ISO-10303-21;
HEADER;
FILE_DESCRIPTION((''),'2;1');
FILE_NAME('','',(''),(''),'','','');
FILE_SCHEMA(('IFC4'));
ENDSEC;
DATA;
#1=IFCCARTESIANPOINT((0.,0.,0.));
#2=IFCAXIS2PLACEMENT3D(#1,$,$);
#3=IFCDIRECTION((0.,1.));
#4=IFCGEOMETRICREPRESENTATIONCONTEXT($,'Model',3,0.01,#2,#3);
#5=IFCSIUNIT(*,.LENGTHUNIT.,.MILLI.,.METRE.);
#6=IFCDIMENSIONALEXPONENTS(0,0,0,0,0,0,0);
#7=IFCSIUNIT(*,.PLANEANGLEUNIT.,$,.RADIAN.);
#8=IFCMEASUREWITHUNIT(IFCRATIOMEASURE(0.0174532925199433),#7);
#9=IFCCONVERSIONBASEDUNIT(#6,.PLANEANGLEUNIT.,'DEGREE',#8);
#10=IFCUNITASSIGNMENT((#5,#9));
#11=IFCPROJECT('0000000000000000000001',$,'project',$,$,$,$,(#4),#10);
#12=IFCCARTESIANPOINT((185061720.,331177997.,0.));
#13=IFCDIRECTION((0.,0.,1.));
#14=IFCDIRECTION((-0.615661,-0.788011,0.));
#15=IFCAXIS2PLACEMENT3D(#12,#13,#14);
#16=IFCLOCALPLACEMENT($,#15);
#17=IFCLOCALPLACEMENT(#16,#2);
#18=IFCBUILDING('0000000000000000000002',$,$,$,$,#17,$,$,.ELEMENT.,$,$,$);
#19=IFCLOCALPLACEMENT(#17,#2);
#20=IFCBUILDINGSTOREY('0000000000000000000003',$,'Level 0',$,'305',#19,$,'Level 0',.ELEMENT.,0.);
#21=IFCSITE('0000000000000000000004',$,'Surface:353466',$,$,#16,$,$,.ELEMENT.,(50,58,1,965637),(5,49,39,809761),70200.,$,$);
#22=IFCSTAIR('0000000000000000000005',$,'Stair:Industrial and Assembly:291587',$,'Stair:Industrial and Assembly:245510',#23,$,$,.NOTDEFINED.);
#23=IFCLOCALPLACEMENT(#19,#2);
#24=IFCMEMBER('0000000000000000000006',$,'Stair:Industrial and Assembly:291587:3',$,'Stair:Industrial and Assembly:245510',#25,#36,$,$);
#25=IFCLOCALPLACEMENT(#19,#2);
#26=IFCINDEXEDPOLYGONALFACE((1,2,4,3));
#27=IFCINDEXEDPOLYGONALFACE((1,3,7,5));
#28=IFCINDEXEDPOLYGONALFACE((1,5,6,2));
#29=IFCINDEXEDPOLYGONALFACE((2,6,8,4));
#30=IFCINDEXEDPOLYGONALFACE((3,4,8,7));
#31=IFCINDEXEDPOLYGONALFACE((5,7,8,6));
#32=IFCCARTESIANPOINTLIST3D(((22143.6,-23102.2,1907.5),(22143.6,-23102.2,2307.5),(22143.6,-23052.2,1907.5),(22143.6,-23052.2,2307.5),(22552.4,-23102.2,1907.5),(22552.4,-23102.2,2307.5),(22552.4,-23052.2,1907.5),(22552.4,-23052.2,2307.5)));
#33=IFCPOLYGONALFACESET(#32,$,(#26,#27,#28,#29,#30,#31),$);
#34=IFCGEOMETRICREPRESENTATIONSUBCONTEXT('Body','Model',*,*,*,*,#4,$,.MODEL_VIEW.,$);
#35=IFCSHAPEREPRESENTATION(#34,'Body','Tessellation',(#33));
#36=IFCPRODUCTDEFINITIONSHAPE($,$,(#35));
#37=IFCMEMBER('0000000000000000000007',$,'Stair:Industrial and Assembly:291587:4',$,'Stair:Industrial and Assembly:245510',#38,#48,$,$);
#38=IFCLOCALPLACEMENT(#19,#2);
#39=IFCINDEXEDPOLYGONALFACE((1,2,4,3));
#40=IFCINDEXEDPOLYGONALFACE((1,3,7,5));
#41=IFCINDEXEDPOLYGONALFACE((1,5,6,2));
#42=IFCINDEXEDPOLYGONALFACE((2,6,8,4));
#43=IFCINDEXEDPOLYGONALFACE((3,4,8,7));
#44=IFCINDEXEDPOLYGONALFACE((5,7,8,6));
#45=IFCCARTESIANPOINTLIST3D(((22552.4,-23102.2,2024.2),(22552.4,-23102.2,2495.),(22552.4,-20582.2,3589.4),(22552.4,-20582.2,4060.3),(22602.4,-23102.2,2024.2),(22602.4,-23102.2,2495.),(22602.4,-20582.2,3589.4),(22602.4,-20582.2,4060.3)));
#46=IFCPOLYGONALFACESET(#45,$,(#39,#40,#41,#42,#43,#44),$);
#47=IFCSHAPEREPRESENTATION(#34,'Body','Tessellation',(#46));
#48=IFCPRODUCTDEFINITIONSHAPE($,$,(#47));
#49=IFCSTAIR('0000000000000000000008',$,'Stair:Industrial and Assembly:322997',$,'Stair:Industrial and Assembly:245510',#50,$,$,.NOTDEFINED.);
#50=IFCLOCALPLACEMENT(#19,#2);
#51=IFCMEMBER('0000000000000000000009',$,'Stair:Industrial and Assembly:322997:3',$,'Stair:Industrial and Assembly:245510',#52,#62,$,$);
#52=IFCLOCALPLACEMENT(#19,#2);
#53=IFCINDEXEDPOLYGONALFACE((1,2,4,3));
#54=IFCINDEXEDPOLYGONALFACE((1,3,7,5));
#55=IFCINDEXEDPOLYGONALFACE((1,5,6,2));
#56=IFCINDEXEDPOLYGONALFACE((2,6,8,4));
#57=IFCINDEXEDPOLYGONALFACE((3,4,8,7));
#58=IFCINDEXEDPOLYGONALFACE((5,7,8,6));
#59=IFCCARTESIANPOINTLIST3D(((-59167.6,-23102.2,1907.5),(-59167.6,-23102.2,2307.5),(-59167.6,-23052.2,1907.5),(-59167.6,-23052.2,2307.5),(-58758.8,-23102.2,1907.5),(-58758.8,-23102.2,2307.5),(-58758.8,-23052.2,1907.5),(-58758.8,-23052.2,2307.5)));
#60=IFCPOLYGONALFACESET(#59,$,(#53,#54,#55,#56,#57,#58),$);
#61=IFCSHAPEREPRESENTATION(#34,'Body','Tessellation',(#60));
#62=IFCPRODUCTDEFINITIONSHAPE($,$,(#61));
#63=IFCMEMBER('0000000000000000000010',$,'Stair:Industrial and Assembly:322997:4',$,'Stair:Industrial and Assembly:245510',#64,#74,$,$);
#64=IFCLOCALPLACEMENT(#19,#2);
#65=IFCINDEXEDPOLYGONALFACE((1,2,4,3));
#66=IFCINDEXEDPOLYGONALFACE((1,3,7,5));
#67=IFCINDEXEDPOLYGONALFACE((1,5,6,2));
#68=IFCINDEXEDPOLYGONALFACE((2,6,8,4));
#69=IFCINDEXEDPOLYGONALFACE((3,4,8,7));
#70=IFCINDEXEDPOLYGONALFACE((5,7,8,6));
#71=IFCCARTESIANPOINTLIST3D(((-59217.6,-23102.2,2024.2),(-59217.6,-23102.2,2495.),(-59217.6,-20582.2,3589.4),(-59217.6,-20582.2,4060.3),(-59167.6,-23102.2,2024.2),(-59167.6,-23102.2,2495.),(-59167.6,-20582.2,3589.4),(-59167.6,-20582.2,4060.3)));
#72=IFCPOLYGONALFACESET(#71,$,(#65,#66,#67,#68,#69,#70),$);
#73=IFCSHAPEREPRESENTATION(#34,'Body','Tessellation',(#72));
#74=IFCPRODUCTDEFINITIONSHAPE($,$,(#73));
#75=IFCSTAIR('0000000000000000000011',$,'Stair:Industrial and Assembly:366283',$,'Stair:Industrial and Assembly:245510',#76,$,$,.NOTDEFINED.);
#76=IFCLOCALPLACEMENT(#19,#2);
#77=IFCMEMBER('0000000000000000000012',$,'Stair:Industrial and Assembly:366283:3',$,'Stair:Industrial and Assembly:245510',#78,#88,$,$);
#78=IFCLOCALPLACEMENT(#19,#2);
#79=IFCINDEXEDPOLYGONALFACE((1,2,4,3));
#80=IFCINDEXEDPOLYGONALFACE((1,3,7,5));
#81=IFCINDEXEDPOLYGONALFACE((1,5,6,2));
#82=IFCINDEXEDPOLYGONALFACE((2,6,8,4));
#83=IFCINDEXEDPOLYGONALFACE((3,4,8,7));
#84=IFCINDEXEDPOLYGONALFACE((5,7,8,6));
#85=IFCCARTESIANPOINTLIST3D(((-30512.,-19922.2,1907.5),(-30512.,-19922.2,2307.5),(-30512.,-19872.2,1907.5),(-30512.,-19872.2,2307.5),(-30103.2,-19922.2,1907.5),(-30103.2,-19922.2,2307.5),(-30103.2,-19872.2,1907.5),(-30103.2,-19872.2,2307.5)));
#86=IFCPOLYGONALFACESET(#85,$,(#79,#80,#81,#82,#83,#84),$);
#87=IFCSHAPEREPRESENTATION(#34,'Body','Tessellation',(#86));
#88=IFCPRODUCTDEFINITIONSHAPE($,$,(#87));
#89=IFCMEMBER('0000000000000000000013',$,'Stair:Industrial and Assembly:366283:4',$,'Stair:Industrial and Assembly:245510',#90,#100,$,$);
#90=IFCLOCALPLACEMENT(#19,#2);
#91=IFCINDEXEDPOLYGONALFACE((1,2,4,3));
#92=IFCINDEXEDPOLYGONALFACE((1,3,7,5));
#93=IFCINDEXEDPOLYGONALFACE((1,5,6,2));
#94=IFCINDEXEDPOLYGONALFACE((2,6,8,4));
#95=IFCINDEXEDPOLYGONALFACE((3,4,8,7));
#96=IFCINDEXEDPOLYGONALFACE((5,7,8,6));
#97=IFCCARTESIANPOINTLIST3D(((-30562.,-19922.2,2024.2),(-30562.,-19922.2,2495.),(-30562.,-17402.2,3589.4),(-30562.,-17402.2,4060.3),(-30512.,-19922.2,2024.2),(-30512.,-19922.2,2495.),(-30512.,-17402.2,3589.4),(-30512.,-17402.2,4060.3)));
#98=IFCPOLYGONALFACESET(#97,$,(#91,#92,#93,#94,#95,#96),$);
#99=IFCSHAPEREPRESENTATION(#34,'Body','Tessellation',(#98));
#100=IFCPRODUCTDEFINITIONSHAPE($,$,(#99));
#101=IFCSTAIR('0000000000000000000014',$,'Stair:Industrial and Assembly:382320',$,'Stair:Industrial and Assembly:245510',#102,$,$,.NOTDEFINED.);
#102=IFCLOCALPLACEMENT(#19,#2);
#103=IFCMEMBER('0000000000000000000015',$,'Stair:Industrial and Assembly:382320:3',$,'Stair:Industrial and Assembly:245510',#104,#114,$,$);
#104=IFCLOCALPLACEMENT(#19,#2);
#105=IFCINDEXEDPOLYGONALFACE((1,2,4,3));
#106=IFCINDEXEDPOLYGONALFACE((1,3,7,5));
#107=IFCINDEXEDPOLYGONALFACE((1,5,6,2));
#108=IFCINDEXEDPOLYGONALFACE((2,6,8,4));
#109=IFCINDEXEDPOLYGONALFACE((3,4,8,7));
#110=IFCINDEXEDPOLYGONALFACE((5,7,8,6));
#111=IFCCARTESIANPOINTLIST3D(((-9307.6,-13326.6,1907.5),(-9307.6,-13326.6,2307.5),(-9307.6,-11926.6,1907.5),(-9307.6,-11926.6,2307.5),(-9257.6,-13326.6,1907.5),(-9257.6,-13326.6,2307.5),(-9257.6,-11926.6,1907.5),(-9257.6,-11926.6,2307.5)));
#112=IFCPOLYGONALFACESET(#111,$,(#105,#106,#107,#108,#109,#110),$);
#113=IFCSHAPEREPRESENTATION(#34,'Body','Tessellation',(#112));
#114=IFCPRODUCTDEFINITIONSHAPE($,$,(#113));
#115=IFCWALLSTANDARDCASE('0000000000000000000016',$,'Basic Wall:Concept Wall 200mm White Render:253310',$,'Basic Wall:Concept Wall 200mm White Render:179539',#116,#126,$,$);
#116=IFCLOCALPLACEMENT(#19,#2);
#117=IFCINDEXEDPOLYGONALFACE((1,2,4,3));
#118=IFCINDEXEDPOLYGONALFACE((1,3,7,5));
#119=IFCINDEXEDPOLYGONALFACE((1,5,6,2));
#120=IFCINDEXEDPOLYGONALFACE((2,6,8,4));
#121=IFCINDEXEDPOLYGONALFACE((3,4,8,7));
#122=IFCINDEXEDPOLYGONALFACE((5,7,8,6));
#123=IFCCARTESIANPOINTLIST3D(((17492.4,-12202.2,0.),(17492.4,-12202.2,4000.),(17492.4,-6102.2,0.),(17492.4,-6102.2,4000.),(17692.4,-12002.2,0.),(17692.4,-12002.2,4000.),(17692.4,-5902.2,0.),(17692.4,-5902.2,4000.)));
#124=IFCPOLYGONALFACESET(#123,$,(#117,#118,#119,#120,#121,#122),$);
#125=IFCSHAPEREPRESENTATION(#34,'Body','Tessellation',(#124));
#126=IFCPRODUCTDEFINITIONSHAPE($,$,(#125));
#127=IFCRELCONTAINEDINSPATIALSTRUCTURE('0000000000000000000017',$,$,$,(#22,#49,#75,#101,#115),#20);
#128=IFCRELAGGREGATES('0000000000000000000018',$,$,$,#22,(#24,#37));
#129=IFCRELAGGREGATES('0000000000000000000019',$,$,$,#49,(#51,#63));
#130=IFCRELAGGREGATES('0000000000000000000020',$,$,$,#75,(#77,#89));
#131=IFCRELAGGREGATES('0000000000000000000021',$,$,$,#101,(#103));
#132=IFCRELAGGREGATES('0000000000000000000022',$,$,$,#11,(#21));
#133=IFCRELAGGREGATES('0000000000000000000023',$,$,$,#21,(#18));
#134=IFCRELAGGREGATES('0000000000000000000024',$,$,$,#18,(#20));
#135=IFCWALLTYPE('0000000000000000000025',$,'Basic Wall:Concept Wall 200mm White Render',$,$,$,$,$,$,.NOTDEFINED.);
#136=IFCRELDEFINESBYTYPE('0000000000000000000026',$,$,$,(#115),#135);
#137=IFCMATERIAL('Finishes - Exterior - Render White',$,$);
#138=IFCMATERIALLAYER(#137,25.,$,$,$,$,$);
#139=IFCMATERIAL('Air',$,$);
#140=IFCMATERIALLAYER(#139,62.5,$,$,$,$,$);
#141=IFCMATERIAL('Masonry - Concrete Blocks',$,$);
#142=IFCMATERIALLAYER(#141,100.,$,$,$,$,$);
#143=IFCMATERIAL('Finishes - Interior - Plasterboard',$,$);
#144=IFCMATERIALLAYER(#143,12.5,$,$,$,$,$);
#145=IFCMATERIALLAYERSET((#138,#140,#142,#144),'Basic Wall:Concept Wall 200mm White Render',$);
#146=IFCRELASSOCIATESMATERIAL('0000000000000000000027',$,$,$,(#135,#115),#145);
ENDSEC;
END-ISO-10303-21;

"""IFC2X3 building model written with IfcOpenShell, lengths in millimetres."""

from ifc_helpers import new_model, entity, si_unit, converted_unit, direction, frame, frame_2d, origin, origin_2d_with_axis, place, context, subcontext, project, spatial, polyline, rectangle, outline, extrude, clip, halfspace, material, layer, layer_set, layer_usage, type_object, element, aggregate, save


model = new_model("IFC2X3")

# Units and contexts
model_context = context("Model", 3, precision=0.01, world=origin(), true_north=direction((0.0, 1.0)))
body_context = subcontext(model_context, "Body", "Model", "MODEL_VIEW")
ifc_project = project(units=[si_unit("LENGTHUNIT", "METRE", prefix="MILLI"), converted_unit("PLANEANGLEUNIT", "DEGREE", entity("IfcRatioMeasure", 0.0174532925199433), si_unit("PLANEANGLEUNIT", "RADIAN"), dimensions=[0, 0, 0, 0, 0, 0, 0])], contexts=[model_context])

# Site, building, storey
site_placement = place(None, frame((185061720.0, 331177997.0, 0.0), z_axis=(0.0, 0.0, 1.0), x_axis=(-0.615661, -0.788011, 0.0)))
site = spatial("IfcSite", under=ifc_project, at=site_placement, Name="Surface:353466", CompositionType="ELEMENT", RefLatitude=(50, 58, 1, 965637), RefLongitude=(5, 49, 39, 809761), RefElevation=70200.0)
building_placement = place(site_placement, origin())
building = spatial("IfcBuilding", under=site, at=building_placement, CompositionType="ELEMENT")
storey_placement = place(building_placement, origin())
storey = spatial("IfcBuildingStorey", under=building, at=storey_placement, Name="Level 0", ObjectType="305", LongName="Level 0", CompositionType="ELEMENT", Elevation=0.0)

# Stairs, members
stair_1_placement = place(storey_placement, origin())
stair_1 = element("IfcStair", 1, at=stair_1_placement, inside=storey, Name="Stair:Industrial and Assembly:291587", ObjectType="Stair:Industrial and Assembly:245510", ShapeType="NOTDEFINED")
member_1_placement = place(stair_1_placement, origin())
member_1 = element("IfcMember", 2, at=member_1_placement, Name="Stair:Industrial and Assembly:291587:3", ObjectType="Stair:Industrial and Assembly:245510", context=body_context, shape_type="SweptSolid", body=[
    extrude(rectangle(XDim=408.8, YDim=50.0, at=frame_2d((0.0, 0.0), x_axis=(1.0, 0.0))), frame((22348.0, -23077.2, 1907.5)), (0.0, 0.0, 1.0), 400.0),
])
member_2_placement = place(stair_1_placement, origin())
member_2 = element("IfcMember", 3, at=member_2_placement, Name="Stair:Industrial and Assembly:291587:4", ObjectType="Stair:Industrial and Assembly:245510", context=body_context, shape_type="SweptSolid", body=[
    extrude(outline(polyline([(-1607.5, -200.0), (1359.0, -200.0), (1607.5, 200.0), (-1359.0, 200.0), (-1607.5, -200.0)])), frame((22552.4, -21842.2, 3042.2), z_axis=(1.0, 0.0, 0.0), x_axis=(0.0, 0.849477, 0.527626)), (0.0, 0.0, 1.0), 50.0),
])
stair_2_placement = place(storey_placement, origin())
stair_2 = element("IfcStair", 4, at=stair_2_placement, inside=storey, Name="Stair:Industrial and Assembly:322997", ObjectType="Stair:Industrial and Assembly:245510", ShapeType="NOTDEFINED")
member_3_placement = place(stair_2_placement, origin())
member_3 = element("IfcMember", 5, at=member_3_placement, Name="Stair:Industrial and Assembly:322997:3", ObjectType="Stair:Industrial and Assembly:245510", context=body_context, shape_type="SweptSolid", body=[
    extrude(rectangle(XDim=408.8, YDim=50.0, at=frame_2d((0.0, 0.0), x_axis=(1.0, 0.0))), frame((-58963.2, -23077.2, 1907.5), z_axis=(0.0, 0.0, 1.0), x_axis=(-1.0, 0.0, 0.0)), (0.0, 0.0, 1.0), 400.0),
])
member_4_placement = place(stair_2_placement, origin())
member_4 = element("IfcMember", 6, at=member_4_placement, Name="Stair:Industrial and Assembly:322997:4", ObjectType="Stair:Industrial and Assembly:245510", context=body_context, shape_type="SweptSolid", body=[
    extrude(outline(polyline([(-1607.5, -200.0), (1359.0, -200.0), (1607.5, 200.0), (-1359.0, 200.0), (-1607.5, -200.0)])), frame((-59217.6, -21842.2, 3042.2), z_axis=(1.0, 0.0, 0.0), x_axis=(0.0, 0.849477, 0.527626)), (0.0, 0.0, 1.0), 50.0),
])
stair_3_placement = place(storey_placement, origin())
stair_3 = element("IfcStair", 7, at=stair_3_placement, inside=storey, Name="Stair:Industrial and Assembly:366283", ObjectType="Stair:Industrial and Assembly:245510", ShapeType="NOTDEFINED")
member_5_placement = place(stair_3_placement, origin())
member_5 = element("IfcMember", 8, at=member_5_placement, Name="Stair:Industrial and Assembly:366283:3", ObjectType="Stair:Industrial and Assembly:245510", context=body_context, shape_type="SweptSolid", body=[
    extrude(rectangle(XDim=408.8, YDim=50.0, at=frame_2d((0.0, 0.0), x_axis=(1.0, 0.0))), frame((-30307.6, -19897.2, 1907.5), z_axis=(0.0, 0.0, 1.0), x_axis=(-1.0, 0.0, 0.0)), (0.0, 0.0, 1.0), 400.0),
])
member_6_placement = place(stair_3_placement, origin())
member_6 = element("IfcMember", 9, at=member_6_placement, Name="Stair:Industrial and Assembly:366283:4", ObjectType="Stair:Industrial and Assembly:245510", context=body_context, shape_type="SweptSolid", body=[
    extrude(outline(polyline([(-1607.5, -200.0), (1359.0, -200.0), (1607.5, 200.0), (-1359.0, 200.0), (-1607.5, -200.0)])), frame((-30562.0, -18662.2, 3042.2), z_axis=(1.0, 0.0, 0.0), x_axis=(0.0, 0.849477, 0.527626)), (0.0, 0.0, 1.0), 50.0),
])
stair_4_placement = place(storey_placement, origin())
stair_4 = element("IfcStair", 10, at=stair_4_placement, inside=storey, Name="Stair:Industrial and Assembly:382320", ObjectType="Stair:Industrial and Assembly:245510", ShapeType="NOTDEFINED")
member_7_placement = place(stair_4_placement, origin())
member_7 = element("IfcMember", 11, at=member_7_placement, Name="Stair:Industrial and Assembly:382320:3", ObjectType="Stair:Industrial and Assembly:245510", context=body_context, shape_type="SweptSolid", body=[
    extrude(rectangle(XDim=1400.0, YDim=50.0, at=origin_2d_with_axis()), frame((-9282.6, -12626.6, 1907.5), z_axis=(0.0, 0.0, 1.0), x_axis=(0.0, -1.0, 0.0)), (0.0, 0.0, 1.0), 400.0),
])

# Wall
ifc_material_1 = material(Name="Finishes - Exterior - Render White")
ifc_layer_1 = layer(ifc_material_1, 25.0)
ifc_material_2 = material(Name="Air")
ifc_layer_2 = layer(ifc_material_2, 62.5)
ifc_material_3 = material(Name="Masonry - Concrete Blocks")
ifc_layer_3 = layer(ifc_material_3, 100.0)
ifc_material_4 = material(Name="Finishes - Interior - Plasterboard")
ifc_layer_4 = layer(ifc_material_4, 12.5)
ifc_layer_set_1 = layer_set([ifc_layer_1, ifc_layer_2, ifc_layer_3, ifc_layer_4], Name="Basic Wall:Concept Wall 200mm White Render")
ifc_layer_usage_1 = layer_usage(ifc_layer_set_1, "AXIS2", "NEGATIVE", 100.0)
wall_type = type_object("IfcWallType", Name="Basic Wall:Concept Wall 200mm White Render", PredefinedType="NOTDEFINED", material=ifc_layer_set_1)
wall_placement = place(storey_placement, frame((17592.4, -5902.2, 0.0), z_axis=(0.0, 0.0, 1.0), x_axis=(0.0, -1.0, 0.0)))
element("IfcWallStandardCase", 12, at=wall_placement, inside=storey, type_object=wall_type, material=ifc_layer_usage_1, Name="Basic Wall:Concept Wall 200mm White Render:253310", ObjectType="Basic Wall:Concept Wall 200mm White Render:179539", context=body_context, shape_type="Clipping", body=[
    clip(extrude(outline(polyline([(6300.0, -100.0), (6100.0, 100.0), (0.0, 100.0), (200.0, -100.0), (6300.0, -100.0)])), origin(), (0.0, 0.0, 1.0), 4000.0), halfspace(origin(), True)),
])

aggregate(stair_1, [member_1, member_2])
aggregate(stair_2, [member_3, member_4])
aggregate(stair_3, [member_5, member_6])
aggregate(stair_4, [member_7])

save(model, "model.ifc")
